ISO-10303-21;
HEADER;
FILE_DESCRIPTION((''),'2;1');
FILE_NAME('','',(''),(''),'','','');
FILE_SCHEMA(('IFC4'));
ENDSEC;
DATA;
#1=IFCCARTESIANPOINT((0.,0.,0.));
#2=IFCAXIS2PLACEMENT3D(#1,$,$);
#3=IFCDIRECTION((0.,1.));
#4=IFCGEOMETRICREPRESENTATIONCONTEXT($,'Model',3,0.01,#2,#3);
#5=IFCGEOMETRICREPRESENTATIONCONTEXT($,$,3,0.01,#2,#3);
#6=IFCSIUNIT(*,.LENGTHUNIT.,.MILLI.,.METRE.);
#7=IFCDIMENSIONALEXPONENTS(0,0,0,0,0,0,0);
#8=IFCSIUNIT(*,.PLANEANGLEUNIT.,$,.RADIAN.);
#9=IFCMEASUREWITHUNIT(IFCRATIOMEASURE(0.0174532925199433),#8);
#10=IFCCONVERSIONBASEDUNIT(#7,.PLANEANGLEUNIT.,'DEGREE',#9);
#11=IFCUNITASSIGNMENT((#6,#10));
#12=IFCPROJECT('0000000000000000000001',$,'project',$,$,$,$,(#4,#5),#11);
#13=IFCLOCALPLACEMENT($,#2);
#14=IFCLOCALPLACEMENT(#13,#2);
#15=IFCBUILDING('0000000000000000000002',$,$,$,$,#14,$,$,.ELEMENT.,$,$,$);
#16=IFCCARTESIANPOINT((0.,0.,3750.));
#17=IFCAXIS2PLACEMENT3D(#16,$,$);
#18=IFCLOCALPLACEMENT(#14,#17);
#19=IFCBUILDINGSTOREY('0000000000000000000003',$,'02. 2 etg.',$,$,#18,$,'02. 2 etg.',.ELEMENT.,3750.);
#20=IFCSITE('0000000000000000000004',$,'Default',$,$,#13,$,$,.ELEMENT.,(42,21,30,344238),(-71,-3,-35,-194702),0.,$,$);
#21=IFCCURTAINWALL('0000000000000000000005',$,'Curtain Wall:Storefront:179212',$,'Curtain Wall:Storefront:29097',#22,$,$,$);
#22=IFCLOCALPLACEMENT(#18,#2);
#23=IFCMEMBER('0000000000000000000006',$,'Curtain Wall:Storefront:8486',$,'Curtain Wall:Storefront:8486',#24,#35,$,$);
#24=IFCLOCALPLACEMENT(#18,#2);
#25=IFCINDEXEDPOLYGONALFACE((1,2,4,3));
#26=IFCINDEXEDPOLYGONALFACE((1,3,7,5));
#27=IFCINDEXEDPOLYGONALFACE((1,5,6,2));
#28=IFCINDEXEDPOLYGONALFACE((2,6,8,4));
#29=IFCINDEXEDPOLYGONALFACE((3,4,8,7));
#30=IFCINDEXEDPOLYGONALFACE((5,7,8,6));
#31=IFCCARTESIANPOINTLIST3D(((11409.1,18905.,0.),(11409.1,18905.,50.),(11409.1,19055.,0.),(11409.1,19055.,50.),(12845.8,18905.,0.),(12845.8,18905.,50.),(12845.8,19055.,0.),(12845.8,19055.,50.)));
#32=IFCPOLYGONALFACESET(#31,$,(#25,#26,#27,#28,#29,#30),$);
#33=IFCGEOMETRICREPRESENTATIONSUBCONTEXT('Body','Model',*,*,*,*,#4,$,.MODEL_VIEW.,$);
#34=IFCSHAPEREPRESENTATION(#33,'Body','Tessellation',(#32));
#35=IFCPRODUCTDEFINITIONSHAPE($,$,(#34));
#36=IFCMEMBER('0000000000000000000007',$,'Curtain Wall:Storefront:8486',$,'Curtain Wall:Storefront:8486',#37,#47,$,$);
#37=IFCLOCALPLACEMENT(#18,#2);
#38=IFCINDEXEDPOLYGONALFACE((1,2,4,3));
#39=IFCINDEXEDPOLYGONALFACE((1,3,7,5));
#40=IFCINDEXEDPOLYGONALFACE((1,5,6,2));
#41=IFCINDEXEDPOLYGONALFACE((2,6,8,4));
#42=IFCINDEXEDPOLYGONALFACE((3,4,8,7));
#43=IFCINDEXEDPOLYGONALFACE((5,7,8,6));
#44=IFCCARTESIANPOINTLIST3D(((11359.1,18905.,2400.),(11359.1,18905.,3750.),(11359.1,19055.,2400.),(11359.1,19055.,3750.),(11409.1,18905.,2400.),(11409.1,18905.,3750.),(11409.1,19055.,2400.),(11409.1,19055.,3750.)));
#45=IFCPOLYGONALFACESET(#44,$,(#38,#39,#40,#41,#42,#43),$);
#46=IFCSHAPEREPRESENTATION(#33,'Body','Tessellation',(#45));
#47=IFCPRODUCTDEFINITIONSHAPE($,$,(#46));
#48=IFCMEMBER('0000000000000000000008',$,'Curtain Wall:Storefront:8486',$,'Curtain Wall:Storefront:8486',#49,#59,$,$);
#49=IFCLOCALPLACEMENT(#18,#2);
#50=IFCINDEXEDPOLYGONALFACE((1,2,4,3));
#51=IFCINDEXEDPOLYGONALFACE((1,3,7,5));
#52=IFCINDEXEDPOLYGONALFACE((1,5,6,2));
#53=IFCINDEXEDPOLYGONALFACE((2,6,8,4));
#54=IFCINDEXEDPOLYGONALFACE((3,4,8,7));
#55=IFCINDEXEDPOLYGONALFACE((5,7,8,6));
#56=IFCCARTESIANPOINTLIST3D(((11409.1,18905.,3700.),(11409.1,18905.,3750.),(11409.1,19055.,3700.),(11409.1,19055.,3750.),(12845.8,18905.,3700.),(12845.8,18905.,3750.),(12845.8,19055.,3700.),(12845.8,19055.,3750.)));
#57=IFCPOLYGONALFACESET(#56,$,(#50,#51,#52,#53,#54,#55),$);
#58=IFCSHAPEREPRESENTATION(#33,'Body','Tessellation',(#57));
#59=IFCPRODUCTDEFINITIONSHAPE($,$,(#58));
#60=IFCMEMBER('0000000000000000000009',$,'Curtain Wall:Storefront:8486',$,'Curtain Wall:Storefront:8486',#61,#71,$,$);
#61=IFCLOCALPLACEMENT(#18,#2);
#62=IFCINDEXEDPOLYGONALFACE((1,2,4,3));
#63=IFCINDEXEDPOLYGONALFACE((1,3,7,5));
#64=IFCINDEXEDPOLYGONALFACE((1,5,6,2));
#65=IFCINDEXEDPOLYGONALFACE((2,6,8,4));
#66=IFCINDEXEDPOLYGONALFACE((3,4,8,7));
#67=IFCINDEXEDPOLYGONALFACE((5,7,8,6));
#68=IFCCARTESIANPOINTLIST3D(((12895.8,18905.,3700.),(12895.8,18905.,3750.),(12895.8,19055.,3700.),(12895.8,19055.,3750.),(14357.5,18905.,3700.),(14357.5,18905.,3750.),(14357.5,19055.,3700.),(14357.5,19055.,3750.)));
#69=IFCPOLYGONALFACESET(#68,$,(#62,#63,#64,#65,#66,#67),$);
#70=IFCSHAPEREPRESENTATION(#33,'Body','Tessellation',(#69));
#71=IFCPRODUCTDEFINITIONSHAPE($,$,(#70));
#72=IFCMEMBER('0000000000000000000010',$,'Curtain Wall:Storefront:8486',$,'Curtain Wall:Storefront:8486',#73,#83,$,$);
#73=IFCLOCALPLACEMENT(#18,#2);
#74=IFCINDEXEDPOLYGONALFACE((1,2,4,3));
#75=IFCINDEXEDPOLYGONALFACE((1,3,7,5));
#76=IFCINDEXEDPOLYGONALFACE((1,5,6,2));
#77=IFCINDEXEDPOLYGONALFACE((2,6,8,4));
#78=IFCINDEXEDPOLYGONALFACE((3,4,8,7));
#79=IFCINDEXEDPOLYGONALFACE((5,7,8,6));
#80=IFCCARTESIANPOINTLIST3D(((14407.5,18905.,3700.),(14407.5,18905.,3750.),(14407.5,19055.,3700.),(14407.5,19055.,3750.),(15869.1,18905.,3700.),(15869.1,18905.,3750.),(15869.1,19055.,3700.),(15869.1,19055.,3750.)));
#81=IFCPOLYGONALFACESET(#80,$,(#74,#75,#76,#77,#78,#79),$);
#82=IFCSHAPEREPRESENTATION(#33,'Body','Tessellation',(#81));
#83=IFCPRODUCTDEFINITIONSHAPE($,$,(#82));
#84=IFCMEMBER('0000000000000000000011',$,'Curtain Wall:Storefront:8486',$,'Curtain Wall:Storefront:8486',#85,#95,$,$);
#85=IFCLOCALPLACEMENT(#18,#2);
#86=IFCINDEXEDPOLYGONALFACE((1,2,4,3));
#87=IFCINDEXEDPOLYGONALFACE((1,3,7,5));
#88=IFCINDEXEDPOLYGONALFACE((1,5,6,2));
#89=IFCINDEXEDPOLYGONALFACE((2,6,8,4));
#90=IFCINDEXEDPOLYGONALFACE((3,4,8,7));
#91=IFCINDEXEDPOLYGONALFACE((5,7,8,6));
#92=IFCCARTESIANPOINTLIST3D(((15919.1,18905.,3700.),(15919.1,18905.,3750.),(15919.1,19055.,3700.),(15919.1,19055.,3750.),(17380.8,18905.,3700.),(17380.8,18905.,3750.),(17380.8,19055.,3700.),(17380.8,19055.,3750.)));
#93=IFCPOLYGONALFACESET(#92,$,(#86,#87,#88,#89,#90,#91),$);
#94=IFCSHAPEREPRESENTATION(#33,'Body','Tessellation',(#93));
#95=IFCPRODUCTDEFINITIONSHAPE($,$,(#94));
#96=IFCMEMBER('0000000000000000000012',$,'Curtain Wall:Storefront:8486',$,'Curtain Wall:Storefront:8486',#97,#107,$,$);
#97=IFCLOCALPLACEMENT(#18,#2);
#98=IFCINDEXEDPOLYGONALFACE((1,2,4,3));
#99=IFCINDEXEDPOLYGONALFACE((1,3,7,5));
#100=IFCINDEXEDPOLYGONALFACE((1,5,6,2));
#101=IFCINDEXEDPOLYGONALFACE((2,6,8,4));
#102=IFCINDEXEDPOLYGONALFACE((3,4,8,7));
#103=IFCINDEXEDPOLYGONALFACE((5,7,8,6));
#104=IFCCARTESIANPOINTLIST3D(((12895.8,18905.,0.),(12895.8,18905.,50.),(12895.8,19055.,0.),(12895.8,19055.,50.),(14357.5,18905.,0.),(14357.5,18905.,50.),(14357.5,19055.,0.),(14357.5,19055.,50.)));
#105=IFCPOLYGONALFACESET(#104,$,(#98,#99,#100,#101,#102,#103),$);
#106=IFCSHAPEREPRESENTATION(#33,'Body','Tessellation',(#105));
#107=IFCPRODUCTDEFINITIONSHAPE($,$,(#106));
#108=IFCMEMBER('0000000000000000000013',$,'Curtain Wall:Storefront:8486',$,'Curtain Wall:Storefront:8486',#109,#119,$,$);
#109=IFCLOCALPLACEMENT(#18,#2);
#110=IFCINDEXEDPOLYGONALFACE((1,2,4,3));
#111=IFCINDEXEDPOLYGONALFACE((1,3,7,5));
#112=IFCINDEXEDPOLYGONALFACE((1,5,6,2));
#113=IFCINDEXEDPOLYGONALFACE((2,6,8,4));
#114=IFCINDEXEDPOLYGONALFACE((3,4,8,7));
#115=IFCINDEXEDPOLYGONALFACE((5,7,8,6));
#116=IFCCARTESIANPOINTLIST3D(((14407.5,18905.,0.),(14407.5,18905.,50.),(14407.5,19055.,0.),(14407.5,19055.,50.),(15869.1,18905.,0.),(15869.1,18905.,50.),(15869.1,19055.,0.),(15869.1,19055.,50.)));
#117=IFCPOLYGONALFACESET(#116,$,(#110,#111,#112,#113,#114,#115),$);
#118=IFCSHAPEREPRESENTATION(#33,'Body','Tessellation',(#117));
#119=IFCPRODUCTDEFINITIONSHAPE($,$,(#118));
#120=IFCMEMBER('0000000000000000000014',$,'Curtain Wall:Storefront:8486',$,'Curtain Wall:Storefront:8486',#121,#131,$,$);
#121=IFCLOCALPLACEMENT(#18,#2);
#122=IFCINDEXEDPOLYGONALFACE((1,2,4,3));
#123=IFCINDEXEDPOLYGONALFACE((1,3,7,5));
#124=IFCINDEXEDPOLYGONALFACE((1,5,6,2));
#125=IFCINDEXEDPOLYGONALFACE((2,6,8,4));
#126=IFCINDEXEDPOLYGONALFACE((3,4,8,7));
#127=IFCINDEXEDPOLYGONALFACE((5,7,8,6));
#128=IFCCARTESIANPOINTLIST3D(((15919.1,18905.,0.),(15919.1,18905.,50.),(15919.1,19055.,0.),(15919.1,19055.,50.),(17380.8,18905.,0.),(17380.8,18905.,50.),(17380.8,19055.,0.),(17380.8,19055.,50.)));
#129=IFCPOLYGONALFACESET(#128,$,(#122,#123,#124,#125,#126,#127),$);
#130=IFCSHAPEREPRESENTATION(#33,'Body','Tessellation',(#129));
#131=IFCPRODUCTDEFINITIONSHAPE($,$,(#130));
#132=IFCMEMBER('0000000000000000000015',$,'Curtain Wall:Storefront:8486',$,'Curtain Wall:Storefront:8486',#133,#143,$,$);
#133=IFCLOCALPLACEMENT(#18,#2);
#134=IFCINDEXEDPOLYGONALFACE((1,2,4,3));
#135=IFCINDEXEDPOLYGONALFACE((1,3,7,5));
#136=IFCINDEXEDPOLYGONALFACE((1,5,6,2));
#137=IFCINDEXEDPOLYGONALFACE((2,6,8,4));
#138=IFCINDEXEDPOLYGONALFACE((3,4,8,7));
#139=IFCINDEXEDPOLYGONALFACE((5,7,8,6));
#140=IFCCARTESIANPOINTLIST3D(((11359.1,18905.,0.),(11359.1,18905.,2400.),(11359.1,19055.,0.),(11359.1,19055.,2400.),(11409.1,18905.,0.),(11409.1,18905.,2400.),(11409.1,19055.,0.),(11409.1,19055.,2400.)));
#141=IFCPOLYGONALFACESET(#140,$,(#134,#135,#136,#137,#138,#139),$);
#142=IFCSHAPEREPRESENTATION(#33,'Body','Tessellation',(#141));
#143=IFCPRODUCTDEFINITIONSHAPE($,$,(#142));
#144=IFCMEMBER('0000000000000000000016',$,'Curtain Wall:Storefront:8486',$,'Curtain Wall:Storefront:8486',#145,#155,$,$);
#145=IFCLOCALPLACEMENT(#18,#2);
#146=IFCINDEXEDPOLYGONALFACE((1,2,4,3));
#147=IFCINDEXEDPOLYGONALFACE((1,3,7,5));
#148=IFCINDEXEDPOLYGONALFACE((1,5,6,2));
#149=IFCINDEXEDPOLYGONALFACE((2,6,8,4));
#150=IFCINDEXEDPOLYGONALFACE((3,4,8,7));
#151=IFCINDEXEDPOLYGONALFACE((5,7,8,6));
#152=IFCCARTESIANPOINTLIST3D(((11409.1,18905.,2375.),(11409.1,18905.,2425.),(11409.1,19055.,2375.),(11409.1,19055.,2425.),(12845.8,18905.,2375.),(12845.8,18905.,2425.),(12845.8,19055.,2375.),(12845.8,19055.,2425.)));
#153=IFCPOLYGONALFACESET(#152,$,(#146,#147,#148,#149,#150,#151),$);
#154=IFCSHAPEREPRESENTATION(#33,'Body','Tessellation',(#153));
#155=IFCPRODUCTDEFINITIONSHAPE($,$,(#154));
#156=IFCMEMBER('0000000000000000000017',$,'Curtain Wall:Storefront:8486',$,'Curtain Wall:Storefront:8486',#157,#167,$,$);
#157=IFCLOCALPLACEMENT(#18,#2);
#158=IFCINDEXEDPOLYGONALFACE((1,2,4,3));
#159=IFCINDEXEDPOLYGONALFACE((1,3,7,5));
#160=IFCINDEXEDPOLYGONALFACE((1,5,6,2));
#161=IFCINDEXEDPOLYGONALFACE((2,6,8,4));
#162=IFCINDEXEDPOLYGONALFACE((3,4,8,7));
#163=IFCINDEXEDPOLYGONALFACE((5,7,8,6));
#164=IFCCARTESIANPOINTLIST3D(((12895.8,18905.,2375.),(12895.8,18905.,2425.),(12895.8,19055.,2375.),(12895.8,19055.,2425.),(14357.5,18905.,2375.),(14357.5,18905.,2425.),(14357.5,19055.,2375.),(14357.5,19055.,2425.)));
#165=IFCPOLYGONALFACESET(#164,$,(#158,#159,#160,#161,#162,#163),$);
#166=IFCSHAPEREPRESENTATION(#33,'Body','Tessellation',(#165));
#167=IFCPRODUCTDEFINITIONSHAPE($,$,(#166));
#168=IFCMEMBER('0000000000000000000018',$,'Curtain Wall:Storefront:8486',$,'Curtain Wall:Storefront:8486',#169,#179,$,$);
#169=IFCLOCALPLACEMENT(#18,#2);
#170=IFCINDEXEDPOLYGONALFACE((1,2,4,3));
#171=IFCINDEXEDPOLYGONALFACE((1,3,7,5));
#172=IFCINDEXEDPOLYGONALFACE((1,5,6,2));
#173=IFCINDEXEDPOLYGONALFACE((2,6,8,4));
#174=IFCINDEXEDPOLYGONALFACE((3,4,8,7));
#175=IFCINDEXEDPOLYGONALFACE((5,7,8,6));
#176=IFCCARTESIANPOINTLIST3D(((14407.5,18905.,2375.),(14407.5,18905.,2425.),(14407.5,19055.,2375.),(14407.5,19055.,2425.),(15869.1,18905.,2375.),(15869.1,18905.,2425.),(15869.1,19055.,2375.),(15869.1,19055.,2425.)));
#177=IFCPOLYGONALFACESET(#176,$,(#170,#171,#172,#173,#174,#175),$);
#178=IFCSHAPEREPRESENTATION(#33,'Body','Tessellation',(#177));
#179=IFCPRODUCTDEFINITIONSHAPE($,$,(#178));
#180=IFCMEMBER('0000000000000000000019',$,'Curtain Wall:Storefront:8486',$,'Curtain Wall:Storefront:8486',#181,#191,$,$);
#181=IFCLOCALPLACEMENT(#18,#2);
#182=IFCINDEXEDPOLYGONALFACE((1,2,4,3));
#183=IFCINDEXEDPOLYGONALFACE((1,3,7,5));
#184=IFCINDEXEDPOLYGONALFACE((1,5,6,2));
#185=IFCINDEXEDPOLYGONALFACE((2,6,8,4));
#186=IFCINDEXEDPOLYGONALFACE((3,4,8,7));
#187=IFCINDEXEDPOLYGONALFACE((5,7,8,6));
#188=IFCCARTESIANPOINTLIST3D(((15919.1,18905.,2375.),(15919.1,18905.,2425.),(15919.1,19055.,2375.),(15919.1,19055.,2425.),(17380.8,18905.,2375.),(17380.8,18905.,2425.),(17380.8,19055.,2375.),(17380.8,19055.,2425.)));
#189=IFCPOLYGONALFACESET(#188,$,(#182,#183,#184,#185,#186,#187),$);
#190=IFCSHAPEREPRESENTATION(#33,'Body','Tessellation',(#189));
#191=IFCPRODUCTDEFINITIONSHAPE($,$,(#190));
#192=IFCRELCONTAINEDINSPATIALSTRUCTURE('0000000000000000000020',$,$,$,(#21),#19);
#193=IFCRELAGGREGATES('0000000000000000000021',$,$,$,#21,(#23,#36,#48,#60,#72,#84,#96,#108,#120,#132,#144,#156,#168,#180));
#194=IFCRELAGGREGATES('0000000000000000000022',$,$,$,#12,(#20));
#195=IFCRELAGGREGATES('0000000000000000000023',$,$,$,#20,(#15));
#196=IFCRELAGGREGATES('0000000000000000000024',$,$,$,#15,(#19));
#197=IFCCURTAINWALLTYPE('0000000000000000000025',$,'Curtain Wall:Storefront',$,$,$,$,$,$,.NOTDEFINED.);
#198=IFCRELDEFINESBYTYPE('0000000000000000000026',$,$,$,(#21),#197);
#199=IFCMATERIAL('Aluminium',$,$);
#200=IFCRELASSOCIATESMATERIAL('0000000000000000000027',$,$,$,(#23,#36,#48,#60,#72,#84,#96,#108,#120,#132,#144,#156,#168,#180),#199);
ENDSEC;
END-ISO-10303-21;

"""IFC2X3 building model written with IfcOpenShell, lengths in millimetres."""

from ifc_helpers import new_model, entity, si_unit, converted_unit, direction, frame, frame_2d, origin, origin_2d_with_axis, place, context, subcontext, project, spatial, rectangle, extrude, material, type_object, element, aggregate, save


model = new_model("IFC2X3")

# Units and contexts
model_context = context("Model", 3, precision=0.01, world=origin(), true_north=direction((0.0, 1.0)))
context_of_model = context(None, 3, precision=0.01, world=origin(), true_north=direction((0.0, 1.0)))
body_context = subcontext(model_context, "Body", "Model", "MODEL_VIEW")
ifc_project = project(units=[si_unit("LENGTHUNIT", "METRE", prefix="MILLI"), converted_unit("PLANEANGLEUNIT", "DEGREE", entity("IfcRatioMeasure", 0.0174532925199433), si_unit("PLANEANGLEUNIT", "RADIAN"), dimensions=[0, 0, 0, 0, 0, 0, 0])], contexts=[model_context, context_of_model])

# Site, building, storey
site_placement = place(None, origin())
site = spatial("IfcSite", under=ifc_project, at=site_placement, Name="Default", CompositionType="ELEMENT", RefLatitude=(42, 21, 30, 344238), RefLongitude=(-71, -3, -35, -194702), RefElevation=0.0)
building_placement = place(site_placement, origin())
building = spatial("IfcBuilding", under=site, at=building_placement, CompositionType="ELEMENT")
storey_placement = place(building_placement, frame((0.0, 0.0, 3750.0)))
storey = spatial("IfcBuildingStorey", under=building, at=storey_placement, Name="02. 2 etg.", LongName="02. 2 etg.", CompositionType="ELEMENT", Elevation=3750.0)

# Curtain wall, members
curtain_wall_type = type_object("IfcCurtainWallType", Name="Curtain Wall:Storefront", PredefinedType="NOTDEFINED")
curtain_wall_placement = place(storey_placement, frame((0.0, 0.0, -3750.0)))
curtain_wall = element("IfcCurtainWall", 1, at=curtain_wall_placement, inside=storey, type_object=curtain_wall_type, Name="Curtain Wall:Storefront:179212", ObjectType="Curtain Wall:Storefront:29097")
ifc_material_1 = material(Name="Aluminium")
member_1_placement = place(curtain_wall_placement, frame((11409.1, 18905.0, 3750.0)))
member_1 = element("IfcMember", 2, at=member_1_placement, material=ifc_material_1, Name="Curtain Wall:Storefront:8486", ObjectType="Curtain Wall:Storefront:8486", context=body_context, shape_type="SweptSolid", body=[
    extrude(rectangle(XDim=1436.7, YDim=150.0, at=frame_2d((0.0, 0.0), x_axis=(1.0, 0.0))), frame((718.3, 75.0, 0.0)), (0.0, 0.0, 1.0), 50.0),
])
member_2_placement = place(curtain_wall_placement, frame((11359.1, 18905.0, 6150.0)))
member_2 = element("IfcMember", 3, at=member_2_placement, material=ifc_material_1, Name="Curtain Wall:Storefront:8486", ObjectType="Curtain Wall:Storefront:8486", context=body_context, shape_type="SweptSolid", body=[
    extrude(rectangle(XDim=50.0, YDim=150.0, at=frame_2d((0.0, 0.0), x_axis=(1.0, 0.0))), frame((25.0, 75.0, 0.0)), (0.0, 0.0, 1.0), 1350.0),
])
member_3_placement = place(curtain_wall_placement, frame((11409.1, 18905.0, 7450.0)))
member_3 = element("IfcMember", 4, at=member_3_placement, material=ifc_material_1, Name="Curtain Wall:Storefront:8486", ObjectType="Curtain Wall:Storefront:8486", context=body_context, shape_type="SweptSolid", body=[
    extrude(rectangle(XDim=1436.7, YDim=150.0, at=frame_2d((0.0, 0.0), x_axis=(1.0, 0.0))), frame((718.3, 75.0, 0.0), z_axis=(0.0, 0.0, 1.0), x_axis=(-1.0, 0.0, 0.0)), (0.0, 0.0, 1.0), 50.0),
])
member_4_placement = place(curtain_wall_placement, frame((12895.8, 18905.0, 7450.0)))
member_4 = element("IfcMember", 5, at=member_4_placement, material=ifc_material_1, Name="Curtain Wall:Storefront:8486", ObjectType="Curtain Wall:Storefront:8486", context=body_context, shape_type="SweptSolid", body=[
    extrude(rectangle(XDim=1461.7, YDim=150.0, at=frame_2d((0.0, 0.0), x_axis=(1.0, 0.0))), frame((730.8, 75.0, 0.0), z_axis=(0.0, 0.0, 1.0), x_axis=(-1.0, 0.0, 0.0)), (0.0, 0.0, 1.0), 50.0),
])
member_5_placement = place(curtain_wall_placement, frame((14407.5, 18905.0, 7450.0)))
member_5 = element("IfcMember", 6, at=member_5_placement, material=ifc_material_1, Name="Curtain Wall:Storefront:8486", ObjectType="Curtain Wall:Storefront:8486", context=body_context, shape_type="SweptSolid", body=[
    extrude(rectangle(XDim=1461.7, YDim=150.0, at=frame_2d((0.0, 0.0), x_axis=(1.0, 0.0))), frame((730.8, 75.0, 0.0), z_axis=(0.0, 0.0, 1.0), x_axis=(-1.0, 0.0, 0.0)), (0.0, 0.0, 1.0), 50.0),
])
member_6_placement = place(curtain_wall_placement, frame((15919.1, 18905.0, 7450.0)))
member_6 = element("IfcMember", 7, at=member_6_placement, material=ifc_material_1, Name="Curtain Wall:Storefront:8486", ObjectType="Curtain Wall:Storefront:8486", context=body_context, shape_type="SweptSolid", body=[
    extrude(rectangle(XDim=1461.7, YDim=150.0, at=frame_2d((0.0, 0.0), x_axis=(1.0, 0.0))), frame((730.8, 75.0, 0.0), z_axis=(0.0, 0.0, 1.0), x_axis=(-1.0, 0.0, 0.0)), (0.0, 0.0, 1.0), 50.0),
])
member_7_placement = place(curtain_wall_placement, frame((12895.8, 18905.0, 3750.0)))
member_7 = element("IfcMember", 8, at=member_7_placement, material=ifc_material_1, Name="Curtain Wall:Storefront:8486", ObjectType="Curtain Wall:Storefront:8486", context=body_context, shape_type="SweptSolid", body=[
    extrude(rectangle(XDim=1461.7, YDim=150.0, at=frame_2d((0.0, 0.0), x_axis=(1.0, 0.0))), frame((730.8, 75.0, 0.0)), (0.0, 0.0, 1.0), 50.0),
])
member_8_placement = place(curtain_wall_placement, frame((14407.5, 18905.0, 3750.0)))
member_8 = element("IfcMember", 9, at=member_8_placement, material=ifc_material_1, Name="Curtain Wall:Storefront:8486", ObjectType="Curtain Wall:Storefront:8486", context=body_context, shape_type="SweptSolid", body=[
    extrude(rectangle(XDim=1461.7, YDim=150.0, at=frame_2d((0.0, 0.0), x_axis=(1.0, 0.0))), frame((730.8, 75.0, 0.0)), (0.0, 0.0, 1.0), 50.0),
])
member_9_placement = place(curtain_wall_placement, frame((15919.1, 18905.0, 3750.0)))
member_9 = element("IfcMember", 10, at=member_9_placement, material=ifc_material_1, Name="Curtain Wall:Storefront:8486", ObjectType="Curtain Wall:Storefront:8486", context=body_context, shape_type="SweptSolid", body=[
    extrude(rectangle(XDim=1461.7, YDim=150.0, at=frame_2d((0.0, 0.0), x_axis=(1.0, 0.0))), frame((730.8, 75.0, 0.0)), (0.0, 0.0, 1.0), 50.0),
])
member_10_placement = place(curtain_wall_placement, frame((11359.1, 18905.0, 3750.0)))
member_10 = element("IfcMember", 11, at=member_10_placement, material=ifc_material_1, Name="Curtain Wall:Storefront:8486", ObjectType="Curtain Wall:Storefront:8486", context=body_context, shape_type="SweptSolid", body=[
    extrude(rectangle(XDim=50.0, YDim=150.0, at=origin_2d_with_axis()), frame((25.0, 75.0, 0.0)), (0.0, 0.0, 1.0), 2400.0),
])
member_11_placement = place(curtain_wall_placement, frame((11409.1, 18905.0, 6125.0)))
member_11 = element("IfcMember", 12, at=member_11_placement, material=ifc_material_1, Name="Curtain Wall:Storefront:8486", ObjectType="Curtain Wall:Storefront:8486", context=body_context, shape_type="SweptSolid", body=[
    extrude(rectangle(XDim=1436.7, YDim=150.0, at=frame_2d((0.0, 0.0), x_axis=(1.0, 0.0))), frame((718.3, 75.0, 0.0), z_axis=(0.0, 0.0, 1.0), x_axis=(-1.0, 0.0, 0.0)), (0.0, 0.0, 1.0), 50.0),
])
member_12_placement = place(curtain_wall_placement, frame((12895.8, 18905.0, 6125.0)))
member_12 = element("IfcMember", 13, at=member_12_placement, material=ifc_material_1, Name="Curtain Wall:Storefront:8486", ObjectType="Curtain Wall:Storefront:8486", context=body_context, shape_type="SweptSolid", body=[
    extrude(rectangle(XDim=1461.7, YDim=150.0, at=frame_2d((0.0, 0.0), x_axis=(1.0, 0.0))), frame((730.8, 75.0, 0.0), z_axis=(0.0, 0.0, 1.0), x_axis=(-1.0, 0.0, 0.0)), (0.0, 0.0, 1.0), 50.0),
])
member_13_placement = place(curtain_wall_placement, frame((14407.5, 18905.0, 6125.0)))
member_13 = element("IfcMember", 14, at=member_13_placement, material=ifc_material_1, Name="Curtain Wall:Storefront:8486", ObjectType="Curtain Wall:Storefront:8486", context=body_context, shape_type="SweptSolid", body=[
    extrude(rectangle(XDim=1461.7, YDim=150.0, at=frame_2d((0.0, 0.0), x_axis=(1.0, 0.0))), frame((730.8, 75.0, 0.0), z_axis=(0.0, 0.0, 1.0), x_axis=(-1.0, 0.0, 0.0)), (0.0, 0.0, 1.0), 50.0),
])
member_14_placement = place(curtain_wall_placement, frame((15919.1, 18905.0, 6125.0)))
member_14 = element("IfcMember", 15, at=member_14_placement, material=ifc_material_1, Name="Curtain Wall:Storefront:8486", ObjectType="Curtain Wall:Storefront:8486", context=body_context, shape_type="SweptSolid", body=[
    extrude(rectangle(XDim=1461.7, YDim=150.0, at=frame_2d((0.0, 0.0), x_axis=(1.0, 0.0))), frame((730.8, 75.0, 0.0), z_axis=(0.0, 0.0, 1.0), x_axis=(-1.0, 0.0, 0.0)), (0.0, 0.0, 1.0), 50.0),
])
aggregate(curtain_wall, [member_1, member_2, member_3, member_4, member_5, member_6, member_7, member_8, member_9, member_10, member_11, member_12, member_13, member_14])

save(model, "model.ifc")
